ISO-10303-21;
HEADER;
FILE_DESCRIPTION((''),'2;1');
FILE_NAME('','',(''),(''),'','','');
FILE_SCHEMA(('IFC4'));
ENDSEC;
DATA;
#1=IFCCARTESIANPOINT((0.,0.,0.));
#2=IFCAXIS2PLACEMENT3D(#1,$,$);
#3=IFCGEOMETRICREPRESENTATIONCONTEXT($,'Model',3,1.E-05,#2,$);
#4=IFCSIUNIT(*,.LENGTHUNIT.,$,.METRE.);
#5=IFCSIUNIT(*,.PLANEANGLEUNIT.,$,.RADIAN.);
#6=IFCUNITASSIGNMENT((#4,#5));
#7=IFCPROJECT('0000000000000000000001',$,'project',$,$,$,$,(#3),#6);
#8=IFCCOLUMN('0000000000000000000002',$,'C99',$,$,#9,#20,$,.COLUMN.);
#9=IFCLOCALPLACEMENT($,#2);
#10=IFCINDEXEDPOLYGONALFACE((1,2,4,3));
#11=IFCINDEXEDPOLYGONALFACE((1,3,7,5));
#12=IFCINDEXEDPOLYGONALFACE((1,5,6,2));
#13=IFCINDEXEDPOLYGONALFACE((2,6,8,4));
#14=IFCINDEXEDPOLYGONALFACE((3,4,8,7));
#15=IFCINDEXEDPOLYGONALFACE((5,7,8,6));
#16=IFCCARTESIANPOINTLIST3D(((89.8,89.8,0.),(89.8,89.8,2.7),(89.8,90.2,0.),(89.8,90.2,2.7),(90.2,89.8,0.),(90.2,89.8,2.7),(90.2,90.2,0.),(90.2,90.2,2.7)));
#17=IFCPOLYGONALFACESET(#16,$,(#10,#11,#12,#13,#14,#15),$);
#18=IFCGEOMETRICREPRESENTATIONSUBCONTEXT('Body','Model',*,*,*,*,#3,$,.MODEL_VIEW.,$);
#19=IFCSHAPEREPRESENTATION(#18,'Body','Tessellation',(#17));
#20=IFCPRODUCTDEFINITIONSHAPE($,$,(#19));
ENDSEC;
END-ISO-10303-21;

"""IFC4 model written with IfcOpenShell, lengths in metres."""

from ifc_helpers import new_model, si_unit, frame, origin, origin_2d, place, context, subcontext, project, rectangle, extrude, element, save


model = new_model("IFC4")

# Units and contexts
model_context = context("Model", 3, precision=1e-05, world=origin())
body_context = subcontext(model_context, "Body", "Model", "MODEL_VIEW")
ifc_project = project(units=[si_unit("LENGTHUNIT", "METRE"), si_unit("PLANEANGLEUNIT", "RADIAN")], contexts=[model_context])

# Column
placement_1 = place(None, origin())
placement_2 = place(placement_1, origin())
placement_3 = place(placement_2, origin())
column_placement = place(placement_3, frame((90.0, 90.0, 0.0)))
element("IfcColumn", 1, at=column_placement, Name="C99", PredefinedType="COLUMN", context=body_context, shape_type="SweptSolid", body=[
    extrude(rectangle(XDim=0.4, YDim=0.4, at=origin_2d()), origin(), (0.0, 0.0, 1.0), 2.7),
])

save(model, "model.ifc")
